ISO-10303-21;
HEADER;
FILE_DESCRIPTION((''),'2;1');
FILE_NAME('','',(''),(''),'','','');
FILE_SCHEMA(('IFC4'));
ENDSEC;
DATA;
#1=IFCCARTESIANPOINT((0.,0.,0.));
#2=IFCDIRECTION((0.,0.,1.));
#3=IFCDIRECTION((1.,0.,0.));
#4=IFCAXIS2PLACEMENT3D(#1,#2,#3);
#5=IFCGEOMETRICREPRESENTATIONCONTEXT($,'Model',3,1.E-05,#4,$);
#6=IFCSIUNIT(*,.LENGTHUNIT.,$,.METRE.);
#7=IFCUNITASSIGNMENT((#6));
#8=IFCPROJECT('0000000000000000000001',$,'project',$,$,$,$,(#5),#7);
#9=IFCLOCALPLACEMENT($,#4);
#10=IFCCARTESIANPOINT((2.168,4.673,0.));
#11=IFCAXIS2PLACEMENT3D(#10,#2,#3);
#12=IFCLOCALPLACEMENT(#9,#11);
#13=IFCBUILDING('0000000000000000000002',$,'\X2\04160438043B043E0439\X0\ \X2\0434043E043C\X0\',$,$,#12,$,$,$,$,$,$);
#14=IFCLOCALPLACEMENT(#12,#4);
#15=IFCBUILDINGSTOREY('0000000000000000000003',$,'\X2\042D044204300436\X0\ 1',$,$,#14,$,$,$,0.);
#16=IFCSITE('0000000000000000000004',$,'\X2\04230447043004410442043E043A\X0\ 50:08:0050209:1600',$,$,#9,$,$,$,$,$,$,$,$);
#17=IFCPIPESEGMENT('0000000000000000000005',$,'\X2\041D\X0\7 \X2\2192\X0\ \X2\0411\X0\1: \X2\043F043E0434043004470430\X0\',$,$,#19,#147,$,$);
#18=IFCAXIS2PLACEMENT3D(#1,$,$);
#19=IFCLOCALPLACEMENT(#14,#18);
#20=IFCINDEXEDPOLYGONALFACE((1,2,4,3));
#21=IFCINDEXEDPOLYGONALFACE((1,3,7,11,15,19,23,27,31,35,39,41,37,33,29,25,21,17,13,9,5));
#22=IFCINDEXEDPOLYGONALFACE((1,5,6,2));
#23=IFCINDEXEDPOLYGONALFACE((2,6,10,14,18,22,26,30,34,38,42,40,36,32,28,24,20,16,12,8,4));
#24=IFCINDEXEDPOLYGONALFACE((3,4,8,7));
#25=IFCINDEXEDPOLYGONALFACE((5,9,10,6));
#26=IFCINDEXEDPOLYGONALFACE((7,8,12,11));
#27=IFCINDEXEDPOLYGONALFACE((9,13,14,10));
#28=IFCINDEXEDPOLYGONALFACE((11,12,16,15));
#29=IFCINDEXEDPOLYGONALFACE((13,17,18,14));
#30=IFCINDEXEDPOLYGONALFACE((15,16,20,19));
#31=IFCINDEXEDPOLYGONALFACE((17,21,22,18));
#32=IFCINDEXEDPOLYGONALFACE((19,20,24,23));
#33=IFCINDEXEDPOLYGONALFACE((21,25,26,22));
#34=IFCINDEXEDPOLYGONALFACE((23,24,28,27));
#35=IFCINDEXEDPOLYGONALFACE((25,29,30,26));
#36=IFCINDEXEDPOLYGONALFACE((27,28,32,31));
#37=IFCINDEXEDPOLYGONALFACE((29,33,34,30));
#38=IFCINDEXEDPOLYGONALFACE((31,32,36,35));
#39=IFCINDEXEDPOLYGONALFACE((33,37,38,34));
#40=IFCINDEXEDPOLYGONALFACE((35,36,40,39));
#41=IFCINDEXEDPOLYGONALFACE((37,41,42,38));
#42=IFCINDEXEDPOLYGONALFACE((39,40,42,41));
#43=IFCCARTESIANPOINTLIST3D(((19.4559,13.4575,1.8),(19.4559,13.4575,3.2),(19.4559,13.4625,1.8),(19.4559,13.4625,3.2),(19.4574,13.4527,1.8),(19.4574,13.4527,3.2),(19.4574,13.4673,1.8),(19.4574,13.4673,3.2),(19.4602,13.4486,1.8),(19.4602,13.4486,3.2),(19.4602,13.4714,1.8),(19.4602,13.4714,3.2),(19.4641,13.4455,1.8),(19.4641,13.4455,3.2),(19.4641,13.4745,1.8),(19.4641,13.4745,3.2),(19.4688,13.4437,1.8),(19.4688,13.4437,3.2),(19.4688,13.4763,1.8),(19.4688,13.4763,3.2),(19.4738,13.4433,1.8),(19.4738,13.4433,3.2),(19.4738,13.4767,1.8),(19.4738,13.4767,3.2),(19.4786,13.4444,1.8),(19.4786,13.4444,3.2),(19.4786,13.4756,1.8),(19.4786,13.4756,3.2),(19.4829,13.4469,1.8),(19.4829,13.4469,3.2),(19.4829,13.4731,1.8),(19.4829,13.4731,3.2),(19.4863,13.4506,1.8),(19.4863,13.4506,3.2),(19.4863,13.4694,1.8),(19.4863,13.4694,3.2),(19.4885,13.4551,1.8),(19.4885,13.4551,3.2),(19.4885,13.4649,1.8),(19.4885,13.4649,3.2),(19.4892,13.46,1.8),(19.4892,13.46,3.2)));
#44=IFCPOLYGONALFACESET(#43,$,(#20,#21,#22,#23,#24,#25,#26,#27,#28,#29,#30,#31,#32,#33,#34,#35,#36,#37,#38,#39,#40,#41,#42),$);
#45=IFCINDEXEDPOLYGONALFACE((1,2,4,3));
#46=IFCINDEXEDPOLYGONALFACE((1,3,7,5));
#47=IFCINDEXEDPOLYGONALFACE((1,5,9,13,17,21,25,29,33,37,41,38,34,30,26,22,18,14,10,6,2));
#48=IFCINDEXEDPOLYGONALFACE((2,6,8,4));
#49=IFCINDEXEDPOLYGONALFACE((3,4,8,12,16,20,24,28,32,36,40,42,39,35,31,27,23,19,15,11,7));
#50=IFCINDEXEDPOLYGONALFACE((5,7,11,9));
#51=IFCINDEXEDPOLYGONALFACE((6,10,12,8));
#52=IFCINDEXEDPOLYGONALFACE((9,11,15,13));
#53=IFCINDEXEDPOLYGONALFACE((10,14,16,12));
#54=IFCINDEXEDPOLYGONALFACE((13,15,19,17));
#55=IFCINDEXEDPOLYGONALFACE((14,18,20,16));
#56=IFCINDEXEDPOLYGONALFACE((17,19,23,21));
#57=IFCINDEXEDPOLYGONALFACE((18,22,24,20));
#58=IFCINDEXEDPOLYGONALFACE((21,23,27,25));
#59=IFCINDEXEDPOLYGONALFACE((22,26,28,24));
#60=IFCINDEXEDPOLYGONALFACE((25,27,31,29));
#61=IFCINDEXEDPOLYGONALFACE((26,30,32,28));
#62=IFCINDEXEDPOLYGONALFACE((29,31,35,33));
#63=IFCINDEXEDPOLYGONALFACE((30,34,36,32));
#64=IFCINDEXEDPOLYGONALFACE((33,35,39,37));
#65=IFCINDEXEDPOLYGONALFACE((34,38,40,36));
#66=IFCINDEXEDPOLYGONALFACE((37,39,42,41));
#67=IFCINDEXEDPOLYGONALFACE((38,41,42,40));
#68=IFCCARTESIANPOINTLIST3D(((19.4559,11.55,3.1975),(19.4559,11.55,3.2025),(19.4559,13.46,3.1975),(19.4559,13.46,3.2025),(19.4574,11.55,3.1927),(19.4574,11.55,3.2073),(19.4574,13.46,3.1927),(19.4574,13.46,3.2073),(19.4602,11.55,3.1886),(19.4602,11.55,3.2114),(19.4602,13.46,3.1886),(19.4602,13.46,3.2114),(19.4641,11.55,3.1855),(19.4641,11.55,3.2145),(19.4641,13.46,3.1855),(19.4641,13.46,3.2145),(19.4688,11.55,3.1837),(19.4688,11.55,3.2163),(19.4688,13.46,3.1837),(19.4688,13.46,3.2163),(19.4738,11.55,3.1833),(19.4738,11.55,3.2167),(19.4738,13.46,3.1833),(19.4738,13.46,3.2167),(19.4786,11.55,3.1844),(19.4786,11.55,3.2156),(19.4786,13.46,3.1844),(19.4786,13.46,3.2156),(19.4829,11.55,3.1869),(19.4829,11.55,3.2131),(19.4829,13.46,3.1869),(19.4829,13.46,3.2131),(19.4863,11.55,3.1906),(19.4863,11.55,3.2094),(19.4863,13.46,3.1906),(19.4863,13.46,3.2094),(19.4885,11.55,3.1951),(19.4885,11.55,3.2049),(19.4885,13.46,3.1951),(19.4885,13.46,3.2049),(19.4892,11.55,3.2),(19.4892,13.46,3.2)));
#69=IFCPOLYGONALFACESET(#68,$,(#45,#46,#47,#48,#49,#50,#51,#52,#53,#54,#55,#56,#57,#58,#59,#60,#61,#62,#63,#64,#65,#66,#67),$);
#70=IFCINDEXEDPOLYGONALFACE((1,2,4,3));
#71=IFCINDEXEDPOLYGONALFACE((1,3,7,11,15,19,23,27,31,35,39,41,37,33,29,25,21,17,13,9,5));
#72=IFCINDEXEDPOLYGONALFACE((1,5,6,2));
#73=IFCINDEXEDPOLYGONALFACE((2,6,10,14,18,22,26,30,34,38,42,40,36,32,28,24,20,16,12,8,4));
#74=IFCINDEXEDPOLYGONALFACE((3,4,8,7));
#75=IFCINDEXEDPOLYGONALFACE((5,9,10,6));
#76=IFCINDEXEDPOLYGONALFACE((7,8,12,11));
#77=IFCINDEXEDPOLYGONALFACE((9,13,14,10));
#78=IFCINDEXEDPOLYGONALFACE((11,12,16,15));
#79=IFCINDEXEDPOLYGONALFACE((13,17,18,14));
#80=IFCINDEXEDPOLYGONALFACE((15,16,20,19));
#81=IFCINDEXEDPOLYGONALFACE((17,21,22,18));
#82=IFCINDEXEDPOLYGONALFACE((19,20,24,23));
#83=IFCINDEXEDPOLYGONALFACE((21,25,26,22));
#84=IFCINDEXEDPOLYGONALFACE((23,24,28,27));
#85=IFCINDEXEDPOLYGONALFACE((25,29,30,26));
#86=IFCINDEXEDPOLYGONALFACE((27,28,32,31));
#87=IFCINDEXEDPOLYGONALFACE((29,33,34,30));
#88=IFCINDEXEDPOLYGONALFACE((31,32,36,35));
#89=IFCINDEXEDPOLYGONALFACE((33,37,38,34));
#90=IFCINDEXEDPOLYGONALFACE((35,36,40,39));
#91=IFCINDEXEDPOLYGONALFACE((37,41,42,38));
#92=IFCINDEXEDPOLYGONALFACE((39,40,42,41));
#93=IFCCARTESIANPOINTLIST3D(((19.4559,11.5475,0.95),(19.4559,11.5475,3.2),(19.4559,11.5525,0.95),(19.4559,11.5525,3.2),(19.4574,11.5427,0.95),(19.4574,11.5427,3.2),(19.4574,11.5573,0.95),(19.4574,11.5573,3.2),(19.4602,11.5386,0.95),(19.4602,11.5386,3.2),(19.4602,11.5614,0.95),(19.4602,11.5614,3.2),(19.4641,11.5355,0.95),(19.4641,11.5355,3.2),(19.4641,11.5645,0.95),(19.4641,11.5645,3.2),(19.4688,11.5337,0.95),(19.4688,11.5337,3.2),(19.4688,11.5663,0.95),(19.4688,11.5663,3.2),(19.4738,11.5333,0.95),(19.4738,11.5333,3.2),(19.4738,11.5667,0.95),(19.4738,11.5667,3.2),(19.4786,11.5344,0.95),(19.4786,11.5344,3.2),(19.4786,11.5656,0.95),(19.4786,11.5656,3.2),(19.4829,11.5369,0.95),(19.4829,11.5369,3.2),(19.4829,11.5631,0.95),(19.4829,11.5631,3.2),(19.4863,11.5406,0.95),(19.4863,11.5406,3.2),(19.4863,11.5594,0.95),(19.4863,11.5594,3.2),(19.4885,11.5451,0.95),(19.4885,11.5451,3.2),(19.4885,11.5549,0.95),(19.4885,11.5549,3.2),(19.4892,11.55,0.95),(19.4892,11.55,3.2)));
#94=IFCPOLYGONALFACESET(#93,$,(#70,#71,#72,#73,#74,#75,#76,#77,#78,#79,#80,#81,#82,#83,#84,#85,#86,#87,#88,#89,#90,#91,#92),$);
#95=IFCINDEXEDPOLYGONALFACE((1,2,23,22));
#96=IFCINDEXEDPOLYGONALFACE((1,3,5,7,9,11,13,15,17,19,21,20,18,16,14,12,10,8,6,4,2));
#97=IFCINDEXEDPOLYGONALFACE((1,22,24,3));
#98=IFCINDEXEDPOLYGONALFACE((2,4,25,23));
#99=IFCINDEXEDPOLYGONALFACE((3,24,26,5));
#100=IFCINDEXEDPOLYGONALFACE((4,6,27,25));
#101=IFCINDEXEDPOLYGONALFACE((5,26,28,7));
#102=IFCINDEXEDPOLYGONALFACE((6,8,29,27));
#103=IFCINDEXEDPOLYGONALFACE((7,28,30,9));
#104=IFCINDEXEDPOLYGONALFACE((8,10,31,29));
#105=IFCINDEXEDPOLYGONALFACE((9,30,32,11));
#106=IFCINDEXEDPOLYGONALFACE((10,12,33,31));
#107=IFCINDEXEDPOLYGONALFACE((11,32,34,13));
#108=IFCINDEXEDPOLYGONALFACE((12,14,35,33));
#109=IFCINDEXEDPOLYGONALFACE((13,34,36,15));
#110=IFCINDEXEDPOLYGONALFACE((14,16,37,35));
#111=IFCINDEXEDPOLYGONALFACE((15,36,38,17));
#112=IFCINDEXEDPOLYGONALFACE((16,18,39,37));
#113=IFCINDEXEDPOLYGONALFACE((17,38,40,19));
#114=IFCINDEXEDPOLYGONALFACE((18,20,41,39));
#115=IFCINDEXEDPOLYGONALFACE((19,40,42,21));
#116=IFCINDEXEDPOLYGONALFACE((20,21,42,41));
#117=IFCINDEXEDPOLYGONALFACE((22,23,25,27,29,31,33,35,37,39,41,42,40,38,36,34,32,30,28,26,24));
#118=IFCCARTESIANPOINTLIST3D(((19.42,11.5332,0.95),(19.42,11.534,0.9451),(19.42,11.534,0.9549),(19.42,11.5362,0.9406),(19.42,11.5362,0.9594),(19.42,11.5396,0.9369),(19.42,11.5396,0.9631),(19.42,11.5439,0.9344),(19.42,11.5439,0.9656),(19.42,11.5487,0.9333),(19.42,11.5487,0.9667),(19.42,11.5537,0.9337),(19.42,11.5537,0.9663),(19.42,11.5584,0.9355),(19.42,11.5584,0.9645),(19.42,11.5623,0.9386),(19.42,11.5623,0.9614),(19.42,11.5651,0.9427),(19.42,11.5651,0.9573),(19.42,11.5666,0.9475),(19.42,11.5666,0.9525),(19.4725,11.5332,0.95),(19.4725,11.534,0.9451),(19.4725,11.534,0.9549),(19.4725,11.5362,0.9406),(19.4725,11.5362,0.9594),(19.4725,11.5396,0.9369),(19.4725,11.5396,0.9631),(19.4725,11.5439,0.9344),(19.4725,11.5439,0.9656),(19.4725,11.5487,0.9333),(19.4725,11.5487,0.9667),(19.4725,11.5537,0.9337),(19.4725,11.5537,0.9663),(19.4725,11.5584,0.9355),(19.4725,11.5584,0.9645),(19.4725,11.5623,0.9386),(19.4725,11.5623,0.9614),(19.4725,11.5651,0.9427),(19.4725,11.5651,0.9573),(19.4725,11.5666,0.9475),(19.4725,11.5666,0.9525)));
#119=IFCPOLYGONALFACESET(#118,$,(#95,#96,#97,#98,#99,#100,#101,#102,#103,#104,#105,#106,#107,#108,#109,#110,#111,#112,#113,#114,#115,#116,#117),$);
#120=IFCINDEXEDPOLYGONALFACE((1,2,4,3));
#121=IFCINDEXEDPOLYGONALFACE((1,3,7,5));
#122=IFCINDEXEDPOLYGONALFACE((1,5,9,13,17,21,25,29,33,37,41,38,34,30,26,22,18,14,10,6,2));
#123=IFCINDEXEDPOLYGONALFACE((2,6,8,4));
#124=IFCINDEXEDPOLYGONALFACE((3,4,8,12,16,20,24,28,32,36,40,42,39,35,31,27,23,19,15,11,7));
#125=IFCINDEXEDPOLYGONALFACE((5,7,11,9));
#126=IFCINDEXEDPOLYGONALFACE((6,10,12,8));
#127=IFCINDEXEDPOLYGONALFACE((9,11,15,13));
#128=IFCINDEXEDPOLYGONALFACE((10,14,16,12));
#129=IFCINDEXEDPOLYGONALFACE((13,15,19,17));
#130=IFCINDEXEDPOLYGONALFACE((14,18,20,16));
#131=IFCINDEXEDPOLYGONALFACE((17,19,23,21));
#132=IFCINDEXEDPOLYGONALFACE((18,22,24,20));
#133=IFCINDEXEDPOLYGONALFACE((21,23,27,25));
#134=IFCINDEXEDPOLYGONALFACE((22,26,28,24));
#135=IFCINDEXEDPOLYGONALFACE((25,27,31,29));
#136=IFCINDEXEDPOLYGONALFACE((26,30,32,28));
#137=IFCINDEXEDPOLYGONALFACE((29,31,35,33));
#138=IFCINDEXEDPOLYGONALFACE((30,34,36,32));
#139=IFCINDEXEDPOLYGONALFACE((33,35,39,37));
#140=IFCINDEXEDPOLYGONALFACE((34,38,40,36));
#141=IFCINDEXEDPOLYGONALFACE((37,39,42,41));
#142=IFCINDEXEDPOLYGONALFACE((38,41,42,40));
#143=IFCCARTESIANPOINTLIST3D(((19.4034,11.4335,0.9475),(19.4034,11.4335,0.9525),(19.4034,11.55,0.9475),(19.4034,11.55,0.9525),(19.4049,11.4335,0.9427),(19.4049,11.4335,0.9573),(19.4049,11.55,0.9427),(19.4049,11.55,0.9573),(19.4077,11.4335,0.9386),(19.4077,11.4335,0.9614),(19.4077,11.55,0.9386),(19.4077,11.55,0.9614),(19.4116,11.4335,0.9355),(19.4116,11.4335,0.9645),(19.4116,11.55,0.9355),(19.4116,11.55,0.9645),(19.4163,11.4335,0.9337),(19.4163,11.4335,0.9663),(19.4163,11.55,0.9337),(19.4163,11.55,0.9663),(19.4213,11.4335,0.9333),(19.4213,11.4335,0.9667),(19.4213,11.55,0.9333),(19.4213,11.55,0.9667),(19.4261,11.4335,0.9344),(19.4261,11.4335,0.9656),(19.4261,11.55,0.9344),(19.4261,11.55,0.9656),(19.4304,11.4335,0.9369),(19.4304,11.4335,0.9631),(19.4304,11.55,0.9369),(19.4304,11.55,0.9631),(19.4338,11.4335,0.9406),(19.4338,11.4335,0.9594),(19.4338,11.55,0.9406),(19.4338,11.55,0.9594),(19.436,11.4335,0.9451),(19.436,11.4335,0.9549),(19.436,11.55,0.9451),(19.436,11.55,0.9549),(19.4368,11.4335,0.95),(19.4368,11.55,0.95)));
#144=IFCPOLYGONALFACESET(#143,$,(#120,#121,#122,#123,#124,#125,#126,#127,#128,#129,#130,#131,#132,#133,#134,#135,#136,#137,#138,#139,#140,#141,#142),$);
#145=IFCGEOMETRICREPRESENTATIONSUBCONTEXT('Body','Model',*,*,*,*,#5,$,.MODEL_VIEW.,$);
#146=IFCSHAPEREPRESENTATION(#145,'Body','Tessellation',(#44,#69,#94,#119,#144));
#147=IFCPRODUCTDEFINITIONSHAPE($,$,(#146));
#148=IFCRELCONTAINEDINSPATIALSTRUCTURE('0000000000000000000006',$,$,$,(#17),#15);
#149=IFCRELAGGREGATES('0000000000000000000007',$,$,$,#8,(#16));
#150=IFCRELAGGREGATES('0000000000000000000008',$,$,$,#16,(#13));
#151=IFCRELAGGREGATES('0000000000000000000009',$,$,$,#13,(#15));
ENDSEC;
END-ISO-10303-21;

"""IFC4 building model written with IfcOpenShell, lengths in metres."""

from ifc_helpers import new_model, si_unit, frame, origin_with_axes, origin_2d, place, context, subcontext, project, spatial, circle, extrude, element, save


model = new_model("IFC4")

# Units and contexts
model_context = context("Model", 3, precision=1e-05, world=origin_with_axes())
body_context = subcontext(model_context, "Body", "Model", "MODEL_VIEW")
ifc_project = project(units=[si_unit("LENGTHUNIT", "METRE")], contexts=[model_context])

# Site, building, storey
site_placement = place(None, origin_with_axes())
site = spatial("IfcSite", under=ifc_project, at=site_placement, Name="Участок 50:08:0050209:1600")
building_placement = place(site_placement, frame((2.168, 4.673, 0.0), z_axis=(0.0, 0.0, 1.0), x_axis=(1.0, 0.0, 0.0)))
building = spatial("IfcBuilding", under=site, at=building_placement, Name="Жилой дом")
storey_placement = place(building_placement, origin_with_axes())
storey = spatial("IfcBuildingStorey", under=building, at=storey_placement, Name="Этаж 1", Elevation=0.0)

# Pipe segment
pipe_segment_1_placement = place(storey_placement, origin_with_axes())
element("IfcPipeSegment", 1, at=pipe_segment_1_placement, inside=storey, Name="Н7 → Б1: подача", context=body_context, shape_type="SweptSolid", body=[
    extrude(circle(Radius=0.0168, at=origin_2d()), frame((19.4725, 13.46, 1.8), z_axis=(0.0, 0.0, 1.0), x_axis=(1.0, 0.0, 0.0)), (0.0, 0.0, 1.0), 1.4),
    extrude(circle(Radius=0.0168, at=origin_2d()), frame((19.4725, 13.46, 3.2), z_axis=(0.0, -1.0, 0.0), x_axis=(1.0, 0.0, 0.0)), (0.0, 0.0, 1.0), 1.91),
    extrude(circle(Radius=0.0168, at=origin_2d()), frame((19.4725, 11.55, 3.2), z_axis=(0.0, 0.0, -1.0), x_axis=(1.0, 0.0, 0.0)), (0.0, 0.0, 1.0), 2.25),
    extrude(circle(Radius=0.0168, at=origin_2d()), frame((19.4725, 11.55, 0.95), z_axis=(-1.0, 0.0, 0.0), x_axis=(0.0, -1.0, 0.0)), (0.0, 0.0, 1.0), 0.0525),
    extrude(circle(Radius=0.0168, at=origin_2d()), frame((19.42, 11.55, 0.95), z_axis=(0.0, -1.0, 0.0), x_axis=(1.0, 0.0, 0.0)), (0.0, 0.0, 1.0), 0.1165),
])

save(model, "model.ifc")
